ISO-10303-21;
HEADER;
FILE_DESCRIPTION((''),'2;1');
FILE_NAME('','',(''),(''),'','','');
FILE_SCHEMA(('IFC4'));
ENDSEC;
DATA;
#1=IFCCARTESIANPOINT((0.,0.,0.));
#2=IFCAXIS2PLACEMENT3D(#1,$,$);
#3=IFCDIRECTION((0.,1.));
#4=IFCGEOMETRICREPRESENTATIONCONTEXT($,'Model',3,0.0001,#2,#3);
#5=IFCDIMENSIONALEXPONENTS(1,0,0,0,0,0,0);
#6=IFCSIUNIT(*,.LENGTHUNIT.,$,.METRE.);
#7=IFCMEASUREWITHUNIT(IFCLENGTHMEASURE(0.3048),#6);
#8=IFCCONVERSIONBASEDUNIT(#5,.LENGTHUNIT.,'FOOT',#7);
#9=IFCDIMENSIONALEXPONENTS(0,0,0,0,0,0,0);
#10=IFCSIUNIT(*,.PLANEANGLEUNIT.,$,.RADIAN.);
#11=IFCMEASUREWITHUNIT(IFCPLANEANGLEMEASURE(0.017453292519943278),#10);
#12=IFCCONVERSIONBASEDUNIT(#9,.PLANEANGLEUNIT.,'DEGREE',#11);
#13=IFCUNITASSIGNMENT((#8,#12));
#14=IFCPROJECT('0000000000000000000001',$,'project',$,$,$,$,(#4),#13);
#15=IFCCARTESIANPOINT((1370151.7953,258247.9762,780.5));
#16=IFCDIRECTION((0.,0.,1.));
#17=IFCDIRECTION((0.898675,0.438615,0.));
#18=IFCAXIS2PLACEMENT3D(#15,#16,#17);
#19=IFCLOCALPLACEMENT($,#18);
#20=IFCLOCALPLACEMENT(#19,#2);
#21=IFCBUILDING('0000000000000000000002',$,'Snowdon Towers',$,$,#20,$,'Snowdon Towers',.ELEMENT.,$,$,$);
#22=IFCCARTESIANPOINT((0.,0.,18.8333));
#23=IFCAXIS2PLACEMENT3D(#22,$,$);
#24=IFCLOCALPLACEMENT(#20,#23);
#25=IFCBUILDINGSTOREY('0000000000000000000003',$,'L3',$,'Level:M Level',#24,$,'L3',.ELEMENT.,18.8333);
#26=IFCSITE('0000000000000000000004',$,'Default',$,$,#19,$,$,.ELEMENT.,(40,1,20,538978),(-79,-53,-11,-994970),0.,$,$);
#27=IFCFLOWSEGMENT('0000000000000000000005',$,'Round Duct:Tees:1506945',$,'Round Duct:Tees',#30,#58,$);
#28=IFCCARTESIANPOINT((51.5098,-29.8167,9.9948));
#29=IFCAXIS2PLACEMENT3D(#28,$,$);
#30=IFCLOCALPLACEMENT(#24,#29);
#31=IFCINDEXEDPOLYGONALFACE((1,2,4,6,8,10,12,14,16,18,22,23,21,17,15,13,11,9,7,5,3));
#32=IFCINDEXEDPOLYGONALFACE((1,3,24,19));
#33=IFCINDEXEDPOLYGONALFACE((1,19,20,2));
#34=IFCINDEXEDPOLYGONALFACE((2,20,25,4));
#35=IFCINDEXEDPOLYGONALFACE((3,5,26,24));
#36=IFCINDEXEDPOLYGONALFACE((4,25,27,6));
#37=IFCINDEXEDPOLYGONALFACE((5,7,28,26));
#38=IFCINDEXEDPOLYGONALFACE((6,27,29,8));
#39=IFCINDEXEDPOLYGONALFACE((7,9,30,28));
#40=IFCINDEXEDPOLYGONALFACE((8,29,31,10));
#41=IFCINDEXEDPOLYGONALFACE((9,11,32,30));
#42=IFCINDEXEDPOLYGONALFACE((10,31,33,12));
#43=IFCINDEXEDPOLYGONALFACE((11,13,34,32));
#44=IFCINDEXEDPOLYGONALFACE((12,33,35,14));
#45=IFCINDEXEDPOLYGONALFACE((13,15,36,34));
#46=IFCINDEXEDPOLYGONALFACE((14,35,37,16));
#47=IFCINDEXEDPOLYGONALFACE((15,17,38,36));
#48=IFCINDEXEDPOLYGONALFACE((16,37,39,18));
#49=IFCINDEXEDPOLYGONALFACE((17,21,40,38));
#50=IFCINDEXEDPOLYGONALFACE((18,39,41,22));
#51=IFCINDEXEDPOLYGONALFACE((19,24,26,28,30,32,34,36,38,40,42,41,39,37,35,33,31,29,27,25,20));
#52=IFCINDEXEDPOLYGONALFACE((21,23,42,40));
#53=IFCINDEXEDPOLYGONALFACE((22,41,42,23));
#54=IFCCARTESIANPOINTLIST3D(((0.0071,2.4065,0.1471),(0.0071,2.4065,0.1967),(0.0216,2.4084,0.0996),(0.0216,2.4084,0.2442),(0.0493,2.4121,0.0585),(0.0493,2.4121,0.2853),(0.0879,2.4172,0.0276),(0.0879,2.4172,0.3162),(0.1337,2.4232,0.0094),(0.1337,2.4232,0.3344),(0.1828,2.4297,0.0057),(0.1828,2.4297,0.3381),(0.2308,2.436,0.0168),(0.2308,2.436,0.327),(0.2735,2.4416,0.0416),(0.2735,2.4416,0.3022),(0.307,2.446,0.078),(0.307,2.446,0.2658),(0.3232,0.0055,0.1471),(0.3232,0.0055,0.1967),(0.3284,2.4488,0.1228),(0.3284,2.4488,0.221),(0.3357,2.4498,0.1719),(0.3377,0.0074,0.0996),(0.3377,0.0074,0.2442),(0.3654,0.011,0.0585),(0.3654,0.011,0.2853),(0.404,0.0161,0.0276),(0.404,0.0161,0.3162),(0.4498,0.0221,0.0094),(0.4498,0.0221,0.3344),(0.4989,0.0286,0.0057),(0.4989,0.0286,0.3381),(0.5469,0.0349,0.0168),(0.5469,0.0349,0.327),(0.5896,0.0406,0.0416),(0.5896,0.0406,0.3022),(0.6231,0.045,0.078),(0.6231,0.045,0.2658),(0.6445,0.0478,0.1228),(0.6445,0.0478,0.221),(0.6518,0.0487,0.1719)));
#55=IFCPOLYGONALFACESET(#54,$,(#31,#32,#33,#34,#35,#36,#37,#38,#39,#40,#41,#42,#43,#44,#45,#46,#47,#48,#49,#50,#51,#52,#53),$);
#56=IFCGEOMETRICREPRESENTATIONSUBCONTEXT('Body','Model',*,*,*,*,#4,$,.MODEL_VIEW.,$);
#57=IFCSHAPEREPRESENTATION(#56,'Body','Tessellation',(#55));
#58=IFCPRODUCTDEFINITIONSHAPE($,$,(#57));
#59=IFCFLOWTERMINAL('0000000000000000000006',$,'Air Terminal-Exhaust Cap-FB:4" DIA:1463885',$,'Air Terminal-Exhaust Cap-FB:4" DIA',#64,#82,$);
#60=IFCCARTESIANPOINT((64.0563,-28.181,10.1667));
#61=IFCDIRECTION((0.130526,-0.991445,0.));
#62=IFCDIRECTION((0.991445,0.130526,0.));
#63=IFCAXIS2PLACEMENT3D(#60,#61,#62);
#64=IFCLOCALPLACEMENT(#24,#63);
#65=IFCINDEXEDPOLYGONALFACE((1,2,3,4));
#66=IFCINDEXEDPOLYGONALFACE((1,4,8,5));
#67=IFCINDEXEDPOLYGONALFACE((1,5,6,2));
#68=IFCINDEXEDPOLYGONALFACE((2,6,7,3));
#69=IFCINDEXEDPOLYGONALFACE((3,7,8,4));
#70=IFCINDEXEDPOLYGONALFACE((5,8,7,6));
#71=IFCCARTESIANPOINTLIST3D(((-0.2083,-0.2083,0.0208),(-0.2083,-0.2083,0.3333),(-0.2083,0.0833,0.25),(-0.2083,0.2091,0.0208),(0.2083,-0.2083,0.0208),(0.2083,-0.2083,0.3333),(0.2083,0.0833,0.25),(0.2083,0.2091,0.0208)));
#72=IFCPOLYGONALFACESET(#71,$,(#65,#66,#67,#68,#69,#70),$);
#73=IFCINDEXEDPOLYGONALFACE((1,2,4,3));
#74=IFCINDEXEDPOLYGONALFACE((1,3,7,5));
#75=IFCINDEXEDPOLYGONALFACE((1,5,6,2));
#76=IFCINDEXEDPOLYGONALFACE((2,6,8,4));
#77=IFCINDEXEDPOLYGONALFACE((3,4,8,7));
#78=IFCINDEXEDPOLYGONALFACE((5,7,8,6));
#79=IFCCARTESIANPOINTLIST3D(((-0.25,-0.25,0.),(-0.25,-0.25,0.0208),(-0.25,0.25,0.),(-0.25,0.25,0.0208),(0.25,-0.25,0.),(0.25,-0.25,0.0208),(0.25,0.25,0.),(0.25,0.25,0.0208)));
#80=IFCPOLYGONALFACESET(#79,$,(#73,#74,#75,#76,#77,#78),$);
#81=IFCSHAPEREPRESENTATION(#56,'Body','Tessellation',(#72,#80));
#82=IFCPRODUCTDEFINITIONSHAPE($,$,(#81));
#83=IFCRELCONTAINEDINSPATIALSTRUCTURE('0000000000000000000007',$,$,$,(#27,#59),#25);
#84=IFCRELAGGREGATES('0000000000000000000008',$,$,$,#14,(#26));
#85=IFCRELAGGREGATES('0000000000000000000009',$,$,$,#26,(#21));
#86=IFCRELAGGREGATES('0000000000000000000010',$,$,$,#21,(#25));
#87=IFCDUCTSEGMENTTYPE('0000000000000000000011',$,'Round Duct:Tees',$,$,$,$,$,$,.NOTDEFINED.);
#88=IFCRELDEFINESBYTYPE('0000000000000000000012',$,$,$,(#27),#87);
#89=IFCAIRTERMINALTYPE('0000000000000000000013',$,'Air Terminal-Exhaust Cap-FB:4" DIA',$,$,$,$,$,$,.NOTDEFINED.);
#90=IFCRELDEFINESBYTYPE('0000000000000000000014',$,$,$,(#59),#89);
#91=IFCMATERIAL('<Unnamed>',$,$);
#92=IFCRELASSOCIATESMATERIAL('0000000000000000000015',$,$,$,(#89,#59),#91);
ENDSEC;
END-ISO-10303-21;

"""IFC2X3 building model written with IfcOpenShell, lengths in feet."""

from ifc_helpers import new_model, entity, si_unit, converted_unit, direction, frame, origin, origin_2d_with_axis, place, context, subcontext, project, spatial, polyline, rectangle, circle, outline, extrude, source, transform, mapped, material, type_object, type_shapes, element, save


model = new_model("IFC2X3")

# Units and contexts
model_context = context("Model", 3, precision=0.0001, world=origin(), true_north=direction((0.0, 1.0)))
body_context = subcontext(model_context, "Body", "Model", "MODEL_VIEW")
ifc_project = project(units=[converted_unit("LENGTHUNIT", "FOOT", entity("IfcLengthMeasure", 0.3048), si_unit("LENGTHUNIT", "METRE"), dimensions=[1, 0, 0, 0, 0, 0, 0]), converted_unit("PLANEANGLEUNIT", "DEGREE", entity("IfcPlaneAngleMeasure", 0.017453292519943278), si_unit("PLANEANGLEUNIT", "RADIAN"), dimensions=[0, 0, 0, 0, 0, 0, 0])], contexts=[model_context])

# Site, building, storey
site_placement = place(None, frame((1370151.7953, 258247.9762, 780.5), z_axis=(0.0, 0.0, 1.0), x_axis=(0.898675, 0.438615, 0.0)))
site = spatial("IfcSite", under=ifc_project, at=site_placement, Name="Default", CompositionType="ELEMENT", RefLatitude=(40, 1, 20, 538978), RefLongitude=(-79, -53, -11, -994970), RefElevation=0.0)
building_placement = place(site_placement, origin())
building = spatial("IfcBuilding", under=site, at=building_placement, Name="Snowdon Towers", LongName="Snowdon Towers", CompositionType="ELEMENT")
storey_placement = place(building_placement, frame((0.0, 0.0, 18.8333)))
storey = spatial("IfcBuildingStorey", under=building, at=storey_placement, Name="L3", ObjectType="Level:M Level", LongName="L3", CompositionType="ELEMENT", Elevation=18.8333)

# Flow segment
duct_segment_type = type_object("IfcDuctSegmentType", Name="Round Duct:Tees", PredefinedType="NOTDEFINED")
flow_segment_1_placement = place(storey_placement, frame((51.5098, -29.8167, 9.9948)))
element("IfcFlowSegment", 1, at=flow_segment_1_placement, inside=storey, type_object=duct_segment_type, Name="Round Duct:Tees:1506945", ObjectType="Round Duct:Tees", context=body_context, shape_type="SweptSolid", body=[
    extrude(circle(Radius=0.1667, at=origin_2d_with_axis()), frame((0.4866, 0.027, 0.1719), z_axis=(-0.130526, 0.991445, 0.0), x_axis=(0.991445, 0.130526, 0.0)), (0.0, 0.0, 1.0), 2.4218),
])

# Flow terminal
ifc_material = material(Name="<Unnamed>")
air_terminal_type_1 = type_object("IfcAirTerminalType", Name="Air Terminal-Exhaust Cap-FB:4\" DIA", PredefinedType="NOTDEFINED", material=ifc_material)
shared_shape_1 = source(origin(), body_context, "Body", "SweptSolid", [
    extrude(outline(polyline([(-0.1771, -0.1773), (0.1354, -0.1773), (0.1354, 0.2402), (-0.0938, 0.1144), (-0.1771, -0.1773)])), frame((-0.2083, -0.0311, 0.1562), z_axis=(1.0, 0.0, 0.0), x_axis=(0.0, 0.0, -1.0)), (0.0, 0.0, 1.0), 0.4167),
    extrude(rectangle(XDim=0.5, YDim=0.5, at=origin_2d_with_axis()), frame((0.0, 0.0, 0.0), z_axis=(0.0, 0.0, 1.0), x_axis=(-1.0, 0.0, 0.0)), (0.0, 0.0, 1.0), 0.0208),
])
type_shapes(air_terminal_type_1, [shared_shape_1])
for number, where, z_axis, x_axis, name in (
    (2, (64.0563, -28.181, 10.1667), (0.130526, -0.991445, 0.0), (0.991445, 0.130526, 0.0), "Air Terminal-Exhaust Cap-FB:4\" DIA:1463885"),
):
    element("IfcFlowTerminal", number, at=place(storey_placement, frame(where, z_axis=z_axis, x_axis=x_axis)), inside=storey, type_object=air_terminal_type_1, material=ifc_material, Name=name, ObjectType="Air Terminal-Exhaust Cap-FB:4\" DIA", context=body_context, shape_type="MappedRepresentation", body=[
        mapped(shared_shape_1, transform((0.0, 0.0, 0.0), scale=1.0)),
    ])

save(model, "model.ifc")
